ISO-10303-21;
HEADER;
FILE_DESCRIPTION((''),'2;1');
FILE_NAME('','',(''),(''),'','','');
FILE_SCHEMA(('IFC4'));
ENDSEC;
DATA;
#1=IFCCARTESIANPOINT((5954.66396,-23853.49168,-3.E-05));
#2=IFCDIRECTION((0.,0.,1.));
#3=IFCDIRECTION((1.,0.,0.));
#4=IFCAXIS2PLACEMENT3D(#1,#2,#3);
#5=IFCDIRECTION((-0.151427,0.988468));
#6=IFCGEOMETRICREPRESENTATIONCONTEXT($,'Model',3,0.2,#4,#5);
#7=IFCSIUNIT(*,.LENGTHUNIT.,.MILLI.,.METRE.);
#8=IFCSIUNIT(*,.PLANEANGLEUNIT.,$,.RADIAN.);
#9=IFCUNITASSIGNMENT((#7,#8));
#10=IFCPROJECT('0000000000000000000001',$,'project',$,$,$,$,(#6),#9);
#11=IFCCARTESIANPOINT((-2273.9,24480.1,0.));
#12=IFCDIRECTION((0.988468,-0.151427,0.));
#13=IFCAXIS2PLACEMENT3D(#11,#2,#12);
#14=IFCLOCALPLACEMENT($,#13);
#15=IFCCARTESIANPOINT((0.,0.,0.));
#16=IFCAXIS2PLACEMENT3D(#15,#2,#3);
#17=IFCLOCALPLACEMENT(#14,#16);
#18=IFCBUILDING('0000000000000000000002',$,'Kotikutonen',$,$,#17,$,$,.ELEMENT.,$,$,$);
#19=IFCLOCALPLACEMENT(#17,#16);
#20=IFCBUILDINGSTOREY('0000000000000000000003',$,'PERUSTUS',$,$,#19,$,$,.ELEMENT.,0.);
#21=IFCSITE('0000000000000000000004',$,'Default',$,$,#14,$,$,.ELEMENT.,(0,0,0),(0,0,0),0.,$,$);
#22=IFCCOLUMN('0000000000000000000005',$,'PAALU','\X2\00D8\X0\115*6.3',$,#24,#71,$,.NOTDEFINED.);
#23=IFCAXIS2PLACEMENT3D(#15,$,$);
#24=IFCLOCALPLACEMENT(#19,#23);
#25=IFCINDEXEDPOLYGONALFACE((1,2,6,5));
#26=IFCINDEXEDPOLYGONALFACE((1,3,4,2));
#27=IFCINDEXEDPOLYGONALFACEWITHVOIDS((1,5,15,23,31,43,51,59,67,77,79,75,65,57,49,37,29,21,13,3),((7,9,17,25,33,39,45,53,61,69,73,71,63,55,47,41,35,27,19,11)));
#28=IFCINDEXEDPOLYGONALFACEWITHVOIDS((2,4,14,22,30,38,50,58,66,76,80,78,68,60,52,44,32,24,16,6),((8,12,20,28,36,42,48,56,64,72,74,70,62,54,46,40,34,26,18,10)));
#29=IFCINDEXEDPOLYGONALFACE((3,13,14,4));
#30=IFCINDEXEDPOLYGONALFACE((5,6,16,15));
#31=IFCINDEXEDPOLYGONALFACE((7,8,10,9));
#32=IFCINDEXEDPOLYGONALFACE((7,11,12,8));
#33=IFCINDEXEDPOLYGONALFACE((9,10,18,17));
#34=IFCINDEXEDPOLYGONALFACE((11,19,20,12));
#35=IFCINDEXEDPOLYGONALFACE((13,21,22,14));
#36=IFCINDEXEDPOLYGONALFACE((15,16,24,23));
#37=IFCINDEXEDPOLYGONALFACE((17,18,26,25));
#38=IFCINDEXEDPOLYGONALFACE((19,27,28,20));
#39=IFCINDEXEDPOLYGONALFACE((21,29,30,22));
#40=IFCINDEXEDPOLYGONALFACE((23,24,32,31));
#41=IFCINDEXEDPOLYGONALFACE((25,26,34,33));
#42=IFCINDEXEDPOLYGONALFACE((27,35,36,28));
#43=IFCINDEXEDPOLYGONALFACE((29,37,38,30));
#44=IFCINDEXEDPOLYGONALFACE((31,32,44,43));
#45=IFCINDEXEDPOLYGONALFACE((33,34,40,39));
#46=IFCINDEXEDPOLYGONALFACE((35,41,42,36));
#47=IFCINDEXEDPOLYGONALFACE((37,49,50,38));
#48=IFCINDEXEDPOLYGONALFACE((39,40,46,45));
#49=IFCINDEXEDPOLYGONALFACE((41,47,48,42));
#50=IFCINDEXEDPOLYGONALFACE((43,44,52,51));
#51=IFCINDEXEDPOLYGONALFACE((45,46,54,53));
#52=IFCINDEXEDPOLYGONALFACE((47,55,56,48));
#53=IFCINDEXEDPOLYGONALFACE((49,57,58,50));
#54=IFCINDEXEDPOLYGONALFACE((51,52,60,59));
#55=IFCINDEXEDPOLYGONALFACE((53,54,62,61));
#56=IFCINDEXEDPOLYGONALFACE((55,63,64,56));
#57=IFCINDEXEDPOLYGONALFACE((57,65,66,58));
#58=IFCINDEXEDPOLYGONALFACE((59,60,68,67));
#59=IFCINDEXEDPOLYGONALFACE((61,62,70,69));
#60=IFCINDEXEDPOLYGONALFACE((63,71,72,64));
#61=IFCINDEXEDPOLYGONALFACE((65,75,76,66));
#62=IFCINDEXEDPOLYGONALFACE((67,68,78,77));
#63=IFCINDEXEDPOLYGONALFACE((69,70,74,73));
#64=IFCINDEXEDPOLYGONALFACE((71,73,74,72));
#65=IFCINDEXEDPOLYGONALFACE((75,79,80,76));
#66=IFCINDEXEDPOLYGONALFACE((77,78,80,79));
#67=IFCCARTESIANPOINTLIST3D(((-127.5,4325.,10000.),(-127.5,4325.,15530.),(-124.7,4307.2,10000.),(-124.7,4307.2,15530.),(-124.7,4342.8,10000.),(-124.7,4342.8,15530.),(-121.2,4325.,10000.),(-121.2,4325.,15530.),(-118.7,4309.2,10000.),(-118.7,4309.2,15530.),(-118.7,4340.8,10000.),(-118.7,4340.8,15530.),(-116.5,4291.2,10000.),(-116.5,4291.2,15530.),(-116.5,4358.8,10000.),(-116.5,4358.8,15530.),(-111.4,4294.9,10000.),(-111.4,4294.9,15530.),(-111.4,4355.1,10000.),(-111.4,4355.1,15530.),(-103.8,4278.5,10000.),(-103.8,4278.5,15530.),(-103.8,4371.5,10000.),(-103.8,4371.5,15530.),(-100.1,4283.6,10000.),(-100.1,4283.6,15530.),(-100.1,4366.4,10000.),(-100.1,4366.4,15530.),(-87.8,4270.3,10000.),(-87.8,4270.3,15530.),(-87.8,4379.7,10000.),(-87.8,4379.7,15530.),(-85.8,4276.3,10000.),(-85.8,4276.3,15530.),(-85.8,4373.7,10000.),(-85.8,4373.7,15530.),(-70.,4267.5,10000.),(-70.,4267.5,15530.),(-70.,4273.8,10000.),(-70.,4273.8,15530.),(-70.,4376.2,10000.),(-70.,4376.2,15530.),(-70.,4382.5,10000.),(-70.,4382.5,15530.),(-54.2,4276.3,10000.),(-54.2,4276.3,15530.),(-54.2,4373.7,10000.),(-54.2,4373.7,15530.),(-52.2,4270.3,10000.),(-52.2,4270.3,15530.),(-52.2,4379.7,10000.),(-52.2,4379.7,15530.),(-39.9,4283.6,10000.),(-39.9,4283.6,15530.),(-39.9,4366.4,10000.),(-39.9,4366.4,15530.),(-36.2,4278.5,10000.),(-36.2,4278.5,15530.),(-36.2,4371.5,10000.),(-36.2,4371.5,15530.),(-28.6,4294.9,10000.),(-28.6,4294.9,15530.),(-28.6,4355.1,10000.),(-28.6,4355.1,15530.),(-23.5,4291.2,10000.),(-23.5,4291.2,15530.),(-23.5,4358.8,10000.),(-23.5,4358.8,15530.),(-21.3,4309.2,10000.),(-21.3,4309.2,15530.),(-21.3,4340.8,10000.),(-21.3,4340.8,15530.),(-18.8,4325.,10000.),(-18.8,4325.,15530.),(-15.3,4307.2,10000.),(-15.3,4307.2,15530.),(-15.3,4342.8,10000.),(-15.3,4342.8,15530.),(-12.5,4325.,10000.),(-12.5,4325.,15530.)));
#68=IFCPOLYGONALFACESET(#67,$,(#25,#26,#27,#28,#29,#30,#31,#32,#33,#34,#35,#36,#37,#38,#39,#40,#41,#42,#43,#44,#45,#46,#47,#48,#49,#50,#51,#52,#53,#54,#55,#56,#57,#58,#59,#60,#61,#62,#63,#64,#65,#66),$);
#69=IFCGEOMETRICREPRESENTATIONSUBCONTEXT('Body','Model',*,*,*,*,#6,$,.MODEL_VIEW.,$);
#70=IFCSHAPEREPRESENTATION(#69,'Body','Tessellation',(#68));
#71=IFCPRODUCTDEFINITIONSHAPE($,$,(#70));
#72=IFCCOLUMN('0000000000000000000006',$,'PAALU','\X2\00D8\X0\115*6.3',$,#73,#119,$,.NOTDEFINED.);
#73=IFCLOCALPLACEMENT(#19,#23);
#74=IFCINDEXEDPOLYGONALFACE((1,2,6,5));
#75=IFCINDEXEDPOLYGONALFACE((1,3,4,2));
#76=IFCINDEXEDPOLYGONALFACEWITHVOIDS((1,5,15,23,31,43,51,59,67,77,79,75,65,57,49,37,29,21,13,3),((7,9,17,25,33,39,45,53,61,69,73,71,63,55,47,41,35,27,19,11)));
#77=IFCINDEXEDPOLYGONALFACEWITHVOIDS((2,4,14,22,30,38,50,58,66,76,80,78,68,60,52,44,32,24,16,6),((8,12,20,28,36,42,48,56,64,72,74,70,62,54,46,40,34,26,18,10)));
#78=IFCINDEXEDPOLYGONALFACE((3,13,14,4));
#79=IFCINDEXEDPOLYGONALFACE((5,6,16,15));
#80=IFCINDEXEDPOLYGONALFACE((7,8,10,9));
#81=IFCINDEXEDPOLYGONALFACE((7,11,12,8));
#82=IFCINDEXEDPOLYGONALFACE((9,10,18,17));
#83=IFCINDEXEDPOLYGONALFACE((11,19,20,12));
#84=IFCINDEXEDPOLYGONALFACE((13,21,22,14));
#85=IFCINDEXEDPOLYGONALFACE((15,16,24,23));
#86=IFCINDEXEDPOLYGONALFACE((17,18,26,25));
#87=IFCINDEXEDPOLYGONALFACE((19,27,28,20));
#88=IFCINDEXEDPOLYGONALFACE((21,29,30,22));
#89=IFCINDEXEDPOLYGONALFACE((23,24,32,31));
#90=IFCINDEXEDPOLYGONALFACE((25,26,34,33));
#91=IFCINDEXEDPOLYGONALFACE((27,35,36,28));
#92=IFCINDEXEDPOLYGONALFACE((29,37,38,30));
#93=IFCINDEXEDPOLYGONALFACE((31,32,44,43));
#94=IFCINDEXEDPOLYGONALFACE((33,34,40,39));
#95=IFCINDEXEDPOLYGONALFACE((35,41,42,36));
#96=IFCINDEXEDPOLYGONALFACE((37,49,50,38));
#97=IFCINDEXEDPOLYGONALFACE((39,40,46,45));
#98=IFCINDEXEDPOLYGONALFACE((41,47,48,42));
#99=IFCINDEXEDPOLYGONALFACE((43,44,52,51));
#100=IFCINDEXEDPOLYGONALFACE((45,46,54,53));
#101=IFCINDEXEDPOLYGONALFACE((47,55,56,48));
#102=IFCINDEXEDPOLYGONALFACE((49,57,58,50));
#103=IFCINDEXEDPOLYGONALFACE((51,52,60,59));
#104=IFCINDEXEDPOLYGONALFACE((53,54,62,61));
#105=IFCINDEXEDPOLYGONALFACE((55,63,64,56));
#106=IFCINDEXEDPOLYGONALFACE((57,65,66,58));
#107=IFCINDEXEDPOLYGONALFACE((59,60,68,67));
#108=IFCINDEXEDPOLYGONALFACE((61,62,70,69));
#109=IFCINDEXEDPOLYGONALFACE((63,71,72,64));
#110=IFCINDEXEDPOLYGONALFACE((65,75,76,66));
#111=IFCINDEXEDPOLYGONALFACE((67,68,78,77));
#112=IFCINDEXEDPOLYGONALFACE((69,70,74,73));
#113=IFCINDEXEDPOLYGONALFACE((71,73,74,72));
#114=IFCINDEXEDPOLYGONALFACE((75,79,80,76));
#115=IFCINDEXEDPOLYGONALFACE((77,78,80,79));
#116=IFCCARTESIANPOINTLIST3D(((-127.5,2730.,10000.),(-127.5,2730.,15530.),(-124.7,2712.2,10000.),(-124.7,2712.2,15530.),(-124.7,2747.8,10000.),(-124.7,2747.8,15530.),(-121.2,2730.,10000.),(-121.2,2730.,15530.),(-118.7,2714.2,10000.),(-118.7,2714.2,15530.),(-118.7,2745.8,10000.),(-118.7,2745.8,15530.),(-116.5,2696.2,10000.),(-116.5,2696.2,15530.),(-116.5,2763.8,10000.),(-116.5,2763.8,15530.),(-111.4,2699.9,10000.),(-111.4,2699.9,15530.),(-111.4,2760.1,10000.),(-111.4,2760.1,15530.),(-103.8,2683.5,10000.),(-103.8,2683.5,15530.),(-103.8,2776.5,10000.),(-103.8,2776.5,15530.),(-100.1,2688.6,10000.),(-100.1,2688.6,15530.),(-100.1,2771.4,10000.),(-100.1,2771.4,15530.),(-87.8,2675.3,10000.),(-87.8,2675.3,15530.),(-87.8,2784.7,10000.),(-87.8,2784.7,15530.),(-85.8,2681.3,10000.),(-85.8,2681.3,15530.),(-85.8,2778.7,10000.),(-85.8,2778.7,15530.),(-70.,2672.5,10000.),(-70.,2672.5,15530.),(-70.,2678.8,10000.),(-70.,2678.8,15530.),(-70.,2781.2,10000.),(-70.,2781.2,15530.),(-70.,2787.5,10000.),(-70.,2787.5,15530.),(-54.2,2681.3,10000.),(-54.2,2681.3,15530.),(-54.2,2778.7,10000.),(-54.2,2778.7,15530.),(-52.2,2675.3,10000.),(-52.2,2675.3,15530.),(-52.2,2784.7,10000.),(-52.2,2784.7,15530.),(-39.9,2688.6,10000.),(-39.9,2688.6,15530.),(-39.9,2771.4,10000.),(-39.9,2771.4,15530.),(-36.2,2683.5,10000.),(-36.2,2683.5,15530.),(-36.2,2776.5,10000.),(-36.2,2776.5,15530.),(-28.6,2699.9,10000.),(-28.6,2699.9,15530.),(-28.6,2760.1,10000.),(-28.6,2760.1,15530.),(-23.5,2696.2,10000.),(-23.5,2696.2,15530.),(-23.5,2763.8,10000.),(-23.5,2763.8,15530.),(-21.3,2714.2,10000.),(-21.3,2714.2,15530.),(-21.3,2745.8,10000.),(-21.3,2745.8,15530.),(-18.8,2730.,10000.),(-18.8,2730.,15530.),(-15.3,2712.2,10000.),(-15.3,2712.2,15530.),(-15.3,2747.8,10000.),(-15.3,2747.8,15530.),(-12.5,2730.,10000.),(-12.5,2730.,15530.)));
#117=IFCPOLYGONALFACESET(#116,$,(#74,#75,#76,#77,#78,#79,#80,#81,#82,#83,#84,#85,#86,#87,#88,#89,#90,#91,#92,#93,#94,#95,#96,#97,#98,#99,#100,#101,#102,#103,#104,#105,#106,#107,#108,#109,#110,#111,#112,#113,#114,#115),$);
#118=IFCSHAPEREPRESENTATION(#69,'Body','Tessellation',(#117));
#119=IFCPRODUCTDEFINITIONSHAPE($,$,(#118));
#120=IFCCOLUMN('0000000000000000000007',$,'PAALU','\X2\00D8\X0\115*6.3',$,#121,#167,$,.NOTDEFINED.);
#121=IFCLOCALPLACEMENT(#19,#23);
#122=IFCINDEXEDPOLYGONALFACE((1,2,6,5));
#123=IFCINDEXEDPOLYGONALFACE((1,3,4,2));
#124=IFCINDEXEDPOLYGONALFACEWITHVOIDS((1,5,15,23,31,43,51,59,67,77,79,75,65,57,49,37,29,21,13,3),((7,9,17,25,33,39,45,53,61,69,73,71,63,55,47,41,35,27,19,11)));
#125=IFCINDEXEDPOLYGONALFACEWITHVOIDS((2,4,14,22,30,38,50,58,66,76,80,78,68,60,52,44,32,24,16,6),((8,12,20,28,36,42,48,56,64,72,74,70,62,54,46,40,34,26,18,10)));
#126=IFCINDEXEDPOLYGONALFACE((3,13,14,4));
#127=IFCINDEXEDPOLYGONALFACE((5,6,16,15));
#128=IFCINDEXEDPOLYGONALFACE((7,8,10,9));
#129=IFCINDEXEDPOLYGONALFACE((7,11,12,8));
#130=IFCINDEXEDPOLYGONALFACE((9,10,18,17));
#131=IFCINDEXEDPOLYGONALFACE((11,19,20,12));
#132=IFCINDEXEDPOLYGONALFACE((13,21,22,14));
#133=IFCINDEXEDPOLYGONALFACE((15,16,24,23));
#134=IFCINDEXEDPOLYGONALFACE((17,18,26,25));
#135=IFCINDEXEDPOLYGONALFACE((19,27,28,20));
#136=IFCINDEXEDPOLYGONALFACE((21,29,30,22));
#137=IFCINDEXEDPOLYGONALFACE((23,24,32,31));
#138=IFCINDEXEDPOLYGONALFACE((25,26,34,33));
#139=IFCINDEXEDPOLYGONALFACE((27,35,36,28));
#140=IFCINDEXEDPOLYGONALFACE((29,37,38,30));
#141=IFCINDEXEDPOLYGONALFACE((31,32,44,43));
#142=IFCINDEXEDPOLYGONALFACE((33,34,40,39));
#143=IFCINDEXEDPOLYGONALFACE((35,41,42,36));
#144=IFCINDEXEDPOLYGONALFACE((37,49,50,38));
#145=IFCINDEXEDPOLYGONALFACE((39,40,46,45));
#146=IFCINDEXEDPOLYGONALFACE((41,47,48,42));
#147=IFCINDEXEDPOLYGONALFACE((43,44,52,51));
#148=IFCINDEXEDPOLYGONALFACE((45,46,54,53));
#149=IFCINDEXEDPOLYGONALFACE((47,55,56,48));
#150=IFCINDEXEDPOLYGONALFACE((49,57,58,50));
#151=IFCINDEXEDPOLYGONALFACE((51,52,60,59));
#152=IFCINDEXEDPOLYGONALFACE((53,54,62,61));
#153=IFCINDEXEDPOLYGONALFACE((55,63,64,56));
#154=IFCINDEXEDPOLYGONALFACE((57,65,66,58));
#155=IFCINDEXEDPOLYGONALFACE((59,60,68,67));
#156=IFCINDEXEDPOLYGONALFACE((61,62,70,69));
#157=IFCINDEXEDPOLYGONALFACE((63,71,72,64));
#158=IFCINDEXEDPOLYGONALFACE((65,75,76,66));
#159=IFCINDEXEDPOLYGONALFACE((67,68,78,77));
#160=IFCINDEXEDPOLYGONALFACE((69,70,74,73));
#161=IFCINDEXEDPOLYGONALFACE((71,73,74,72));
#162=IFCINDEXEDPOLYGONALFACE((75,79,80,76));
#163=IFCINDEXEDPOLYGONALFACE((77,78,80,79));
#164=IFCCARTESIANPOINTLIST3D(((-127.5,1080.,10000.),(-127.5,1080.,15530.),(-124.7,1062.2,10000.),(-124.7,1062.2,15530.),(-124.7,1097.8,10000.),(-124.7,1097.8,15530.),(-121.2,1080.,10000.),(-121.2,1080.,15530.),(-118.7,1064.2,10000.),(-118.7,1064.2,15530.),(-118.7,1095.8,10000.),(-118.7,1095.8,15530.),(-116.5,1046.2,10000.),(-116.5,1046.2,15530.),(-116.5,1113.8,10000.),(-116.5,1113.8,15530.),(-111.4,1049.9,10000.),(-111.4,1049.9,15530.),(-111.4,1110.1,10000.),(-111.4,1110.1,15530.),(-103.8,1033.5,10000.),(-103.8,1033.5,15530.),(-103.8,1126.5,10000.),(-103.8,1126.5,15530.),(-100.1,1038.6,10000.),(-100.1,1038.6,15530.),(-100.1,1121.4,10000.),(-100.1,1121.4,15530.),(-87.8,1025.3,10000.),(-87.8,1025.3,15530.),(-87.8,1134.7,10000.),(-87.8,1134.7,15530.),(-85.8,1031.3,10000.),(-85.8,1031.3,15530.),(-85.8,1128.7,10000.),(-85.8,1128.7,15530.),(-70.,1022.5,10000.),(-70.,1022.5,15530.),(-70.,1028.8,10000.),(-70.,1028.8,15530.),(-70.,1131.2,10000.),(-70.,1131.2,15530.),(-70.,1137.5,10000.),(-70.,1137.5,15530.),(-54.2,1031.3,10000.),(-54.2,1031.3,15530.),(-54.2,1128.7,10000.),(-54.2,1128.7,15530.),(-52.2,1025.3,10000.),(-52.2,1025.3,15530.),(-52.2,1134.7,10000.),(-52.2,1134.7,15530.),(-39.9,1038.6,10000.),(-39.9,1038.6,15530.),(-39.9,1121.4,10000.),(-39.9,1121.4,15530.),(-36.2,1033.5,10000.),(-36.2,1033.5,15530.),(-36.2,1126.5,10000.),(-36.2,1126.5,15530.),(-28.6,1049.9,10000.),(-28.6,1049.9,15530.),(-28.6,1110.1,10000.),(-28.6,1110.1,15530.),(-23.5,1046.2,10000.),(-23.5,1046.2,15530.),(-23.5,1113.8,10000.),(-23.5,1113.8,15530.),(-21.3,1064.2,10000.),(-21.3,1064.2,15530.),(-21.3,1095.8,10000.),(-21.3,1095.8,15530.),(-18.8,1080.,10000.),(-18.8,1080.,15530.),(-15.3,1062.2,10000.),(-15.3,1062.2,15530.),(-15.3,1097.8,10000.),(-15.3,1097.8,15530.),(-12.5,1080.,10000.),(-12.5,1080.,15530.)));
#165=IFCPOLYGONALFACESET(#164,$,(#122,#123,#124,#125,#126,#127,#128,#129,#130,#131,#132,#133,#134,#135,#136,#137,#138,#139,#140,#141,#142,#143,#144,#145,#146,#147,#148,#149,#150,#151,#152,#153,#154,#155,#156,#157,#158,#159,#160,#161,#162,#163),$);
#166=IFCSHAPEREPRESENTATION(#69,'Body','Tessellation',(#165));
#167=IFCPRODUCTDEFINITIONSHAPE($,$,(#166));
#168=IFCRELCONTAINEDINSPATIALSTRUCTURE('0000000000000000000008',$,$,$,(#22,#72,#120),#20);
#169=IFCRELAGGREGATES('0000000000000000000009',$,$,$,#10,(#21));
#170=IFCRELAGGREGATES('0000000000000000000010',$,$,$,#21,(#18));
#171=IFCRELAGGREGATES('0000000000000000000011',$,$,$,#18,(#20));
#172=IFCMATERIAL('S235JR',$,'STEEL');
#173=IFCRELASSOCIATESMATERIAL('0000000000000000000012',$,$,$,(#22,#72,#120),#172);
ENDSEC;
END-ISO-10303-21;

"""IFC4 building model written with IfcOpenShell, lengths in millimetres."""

from ifc_helpers import new_model, si_unit, direction, frame, origin_with_axes, place, context, subcontext, project, spatial, line, indexed_curve, outline, extrude, material, element, save


model = new_model("IFC4")

# Units and contexts
model_context = context("Model", 3, precision=0.2, world=frame((5954.66396, -23853.49168, -3e-05), z_axis=(0.0, 0.0, 1.0), x_axis=(1.0, 0.0, 0.0)), true_north=direction((-0.151427, 0.988468)))
body_context = subcontext(model_context, "Body", "Model", "MODEL_VIEW")
ifc_project = project(units=[si_unit("LENGTHUNIT", "METRE", prefix="MILLI"), si_unit("PLANEANGLEUNIT", "RADIAN")], contexts=[model_context])

# Site, building, storey
site_placement = place(None, frame((-2273.9, 24480.1, 0.0), z_axis=(0.0, 0.0, 1.0), x_axis=(0.988468, -0.151427, 0.0)))
site = spatial("IfcSite", under=ifc_project, at=site_placement, Name="Default", CompositionType="ELEMENT", RefLatitude=(0, 0, 0), RefLongitude=(0, 0, 0), RefElevation=0.0)
building_placement = place(site_placement, origin_with_axes())
building = spatial("IfcBuilding", under=site, at=building_placement, Name="Kotikutonen", CompositionType="ELEMENT")
storey_placement = place(building_placement, origin_with_axes())
storey = spatial("IfcBuildingStorey", under=building, at=storey_placement, Name="PERUSTUS", CompositionType="ELEMENT", Elevation=0.0)

# Columns
ifc_material = material(Name="S235JR", Category="STEEL")
for number, where, z_axis, x_axis, name in (
    (1, (-70.0, 4325.0, 10000.0), (-1.0, 0.0, 0.0), (0.0, 0.0, 1.0), "PAALU"),
    (2, (-70.0, 2730.0, 10000.0), (-1.0, 0.0, 0.0), (0.0, 0.0, 1.0), "PAALU"),
    (3, (-70.0, 1080.0, 10000.0), (-1.0, 0.0, 0.0), (0.0, 0.0, 1.0), "PAALU"),
):
    element("IfcColumn", number, at=place(storey_placement, frame(where, z_axis=z_axis, x_axis=x_axis)), inside=storey, material=ifc_material, Name=name, Description="Ø115*6.3", PredefinedType="NOTDEFINED", context=body_context, shape_type="SolidModel", body=[
        extrude(outline(indexed_curve([(57.5, 0.0), (54.7, 17.8), (46.5, 33.8), (33.8, 46.5), (17.8, 54.7), (0.0, 57.5), (-17.8, 54.7), (-33.8, 46.5), (-46.5, 33.8), (-54.7, 17.8), (-57.5, 0.0), (-54.7, -17.8), (-46.5, -33.8), (-33.8, -46.5), (-17.8, -54.7), (0.0, -57.5), (17.8, -54.7), (33.8, -46.5), (46.5, -33.8), (54.7, -17.8)], segments=[line(1, 2, 3, 4, 5, 6, 7, 8, 9, 10, 11, 12, 13, 14, 15, 16, 17, 18, 19, 20, 1)]), holes=[indexed_curve([(51.2, 0.0), (48.7, -15.8), (41.4, -30.1), (30.1, -41.4), (15.8, -48.7), (0.0, -51.2), (-15.8, -48.7), (-30.1, -41.4), (-41.4, -30.1), (-48.7, -15.8), (-51.2, 0.0), (-48.7, 15.8), (-41.4, 30.1), (-30.1, 41.4), (-15.8, 48.7), (0.0, 51.2), (15.8, 48.7), (30.1, 41.4), (41.4, 30.1), (48.7, 15.8)], segments=[line(1, 2, 3, 4, 5, 6, 7, 8, 9, 10, 11, 12, 13, 14, 15, 16, 17, 18, 19, 20, 1)])]), frame((0.0, 0.0, 0.0), z_axis=(-1.0, 0.0, 0.0), x_axis=(0.0, 0.0, 1.0)), (0.0, 0.0, -1.0), 5530.0),
    ])

save(model, "model.ifc")
